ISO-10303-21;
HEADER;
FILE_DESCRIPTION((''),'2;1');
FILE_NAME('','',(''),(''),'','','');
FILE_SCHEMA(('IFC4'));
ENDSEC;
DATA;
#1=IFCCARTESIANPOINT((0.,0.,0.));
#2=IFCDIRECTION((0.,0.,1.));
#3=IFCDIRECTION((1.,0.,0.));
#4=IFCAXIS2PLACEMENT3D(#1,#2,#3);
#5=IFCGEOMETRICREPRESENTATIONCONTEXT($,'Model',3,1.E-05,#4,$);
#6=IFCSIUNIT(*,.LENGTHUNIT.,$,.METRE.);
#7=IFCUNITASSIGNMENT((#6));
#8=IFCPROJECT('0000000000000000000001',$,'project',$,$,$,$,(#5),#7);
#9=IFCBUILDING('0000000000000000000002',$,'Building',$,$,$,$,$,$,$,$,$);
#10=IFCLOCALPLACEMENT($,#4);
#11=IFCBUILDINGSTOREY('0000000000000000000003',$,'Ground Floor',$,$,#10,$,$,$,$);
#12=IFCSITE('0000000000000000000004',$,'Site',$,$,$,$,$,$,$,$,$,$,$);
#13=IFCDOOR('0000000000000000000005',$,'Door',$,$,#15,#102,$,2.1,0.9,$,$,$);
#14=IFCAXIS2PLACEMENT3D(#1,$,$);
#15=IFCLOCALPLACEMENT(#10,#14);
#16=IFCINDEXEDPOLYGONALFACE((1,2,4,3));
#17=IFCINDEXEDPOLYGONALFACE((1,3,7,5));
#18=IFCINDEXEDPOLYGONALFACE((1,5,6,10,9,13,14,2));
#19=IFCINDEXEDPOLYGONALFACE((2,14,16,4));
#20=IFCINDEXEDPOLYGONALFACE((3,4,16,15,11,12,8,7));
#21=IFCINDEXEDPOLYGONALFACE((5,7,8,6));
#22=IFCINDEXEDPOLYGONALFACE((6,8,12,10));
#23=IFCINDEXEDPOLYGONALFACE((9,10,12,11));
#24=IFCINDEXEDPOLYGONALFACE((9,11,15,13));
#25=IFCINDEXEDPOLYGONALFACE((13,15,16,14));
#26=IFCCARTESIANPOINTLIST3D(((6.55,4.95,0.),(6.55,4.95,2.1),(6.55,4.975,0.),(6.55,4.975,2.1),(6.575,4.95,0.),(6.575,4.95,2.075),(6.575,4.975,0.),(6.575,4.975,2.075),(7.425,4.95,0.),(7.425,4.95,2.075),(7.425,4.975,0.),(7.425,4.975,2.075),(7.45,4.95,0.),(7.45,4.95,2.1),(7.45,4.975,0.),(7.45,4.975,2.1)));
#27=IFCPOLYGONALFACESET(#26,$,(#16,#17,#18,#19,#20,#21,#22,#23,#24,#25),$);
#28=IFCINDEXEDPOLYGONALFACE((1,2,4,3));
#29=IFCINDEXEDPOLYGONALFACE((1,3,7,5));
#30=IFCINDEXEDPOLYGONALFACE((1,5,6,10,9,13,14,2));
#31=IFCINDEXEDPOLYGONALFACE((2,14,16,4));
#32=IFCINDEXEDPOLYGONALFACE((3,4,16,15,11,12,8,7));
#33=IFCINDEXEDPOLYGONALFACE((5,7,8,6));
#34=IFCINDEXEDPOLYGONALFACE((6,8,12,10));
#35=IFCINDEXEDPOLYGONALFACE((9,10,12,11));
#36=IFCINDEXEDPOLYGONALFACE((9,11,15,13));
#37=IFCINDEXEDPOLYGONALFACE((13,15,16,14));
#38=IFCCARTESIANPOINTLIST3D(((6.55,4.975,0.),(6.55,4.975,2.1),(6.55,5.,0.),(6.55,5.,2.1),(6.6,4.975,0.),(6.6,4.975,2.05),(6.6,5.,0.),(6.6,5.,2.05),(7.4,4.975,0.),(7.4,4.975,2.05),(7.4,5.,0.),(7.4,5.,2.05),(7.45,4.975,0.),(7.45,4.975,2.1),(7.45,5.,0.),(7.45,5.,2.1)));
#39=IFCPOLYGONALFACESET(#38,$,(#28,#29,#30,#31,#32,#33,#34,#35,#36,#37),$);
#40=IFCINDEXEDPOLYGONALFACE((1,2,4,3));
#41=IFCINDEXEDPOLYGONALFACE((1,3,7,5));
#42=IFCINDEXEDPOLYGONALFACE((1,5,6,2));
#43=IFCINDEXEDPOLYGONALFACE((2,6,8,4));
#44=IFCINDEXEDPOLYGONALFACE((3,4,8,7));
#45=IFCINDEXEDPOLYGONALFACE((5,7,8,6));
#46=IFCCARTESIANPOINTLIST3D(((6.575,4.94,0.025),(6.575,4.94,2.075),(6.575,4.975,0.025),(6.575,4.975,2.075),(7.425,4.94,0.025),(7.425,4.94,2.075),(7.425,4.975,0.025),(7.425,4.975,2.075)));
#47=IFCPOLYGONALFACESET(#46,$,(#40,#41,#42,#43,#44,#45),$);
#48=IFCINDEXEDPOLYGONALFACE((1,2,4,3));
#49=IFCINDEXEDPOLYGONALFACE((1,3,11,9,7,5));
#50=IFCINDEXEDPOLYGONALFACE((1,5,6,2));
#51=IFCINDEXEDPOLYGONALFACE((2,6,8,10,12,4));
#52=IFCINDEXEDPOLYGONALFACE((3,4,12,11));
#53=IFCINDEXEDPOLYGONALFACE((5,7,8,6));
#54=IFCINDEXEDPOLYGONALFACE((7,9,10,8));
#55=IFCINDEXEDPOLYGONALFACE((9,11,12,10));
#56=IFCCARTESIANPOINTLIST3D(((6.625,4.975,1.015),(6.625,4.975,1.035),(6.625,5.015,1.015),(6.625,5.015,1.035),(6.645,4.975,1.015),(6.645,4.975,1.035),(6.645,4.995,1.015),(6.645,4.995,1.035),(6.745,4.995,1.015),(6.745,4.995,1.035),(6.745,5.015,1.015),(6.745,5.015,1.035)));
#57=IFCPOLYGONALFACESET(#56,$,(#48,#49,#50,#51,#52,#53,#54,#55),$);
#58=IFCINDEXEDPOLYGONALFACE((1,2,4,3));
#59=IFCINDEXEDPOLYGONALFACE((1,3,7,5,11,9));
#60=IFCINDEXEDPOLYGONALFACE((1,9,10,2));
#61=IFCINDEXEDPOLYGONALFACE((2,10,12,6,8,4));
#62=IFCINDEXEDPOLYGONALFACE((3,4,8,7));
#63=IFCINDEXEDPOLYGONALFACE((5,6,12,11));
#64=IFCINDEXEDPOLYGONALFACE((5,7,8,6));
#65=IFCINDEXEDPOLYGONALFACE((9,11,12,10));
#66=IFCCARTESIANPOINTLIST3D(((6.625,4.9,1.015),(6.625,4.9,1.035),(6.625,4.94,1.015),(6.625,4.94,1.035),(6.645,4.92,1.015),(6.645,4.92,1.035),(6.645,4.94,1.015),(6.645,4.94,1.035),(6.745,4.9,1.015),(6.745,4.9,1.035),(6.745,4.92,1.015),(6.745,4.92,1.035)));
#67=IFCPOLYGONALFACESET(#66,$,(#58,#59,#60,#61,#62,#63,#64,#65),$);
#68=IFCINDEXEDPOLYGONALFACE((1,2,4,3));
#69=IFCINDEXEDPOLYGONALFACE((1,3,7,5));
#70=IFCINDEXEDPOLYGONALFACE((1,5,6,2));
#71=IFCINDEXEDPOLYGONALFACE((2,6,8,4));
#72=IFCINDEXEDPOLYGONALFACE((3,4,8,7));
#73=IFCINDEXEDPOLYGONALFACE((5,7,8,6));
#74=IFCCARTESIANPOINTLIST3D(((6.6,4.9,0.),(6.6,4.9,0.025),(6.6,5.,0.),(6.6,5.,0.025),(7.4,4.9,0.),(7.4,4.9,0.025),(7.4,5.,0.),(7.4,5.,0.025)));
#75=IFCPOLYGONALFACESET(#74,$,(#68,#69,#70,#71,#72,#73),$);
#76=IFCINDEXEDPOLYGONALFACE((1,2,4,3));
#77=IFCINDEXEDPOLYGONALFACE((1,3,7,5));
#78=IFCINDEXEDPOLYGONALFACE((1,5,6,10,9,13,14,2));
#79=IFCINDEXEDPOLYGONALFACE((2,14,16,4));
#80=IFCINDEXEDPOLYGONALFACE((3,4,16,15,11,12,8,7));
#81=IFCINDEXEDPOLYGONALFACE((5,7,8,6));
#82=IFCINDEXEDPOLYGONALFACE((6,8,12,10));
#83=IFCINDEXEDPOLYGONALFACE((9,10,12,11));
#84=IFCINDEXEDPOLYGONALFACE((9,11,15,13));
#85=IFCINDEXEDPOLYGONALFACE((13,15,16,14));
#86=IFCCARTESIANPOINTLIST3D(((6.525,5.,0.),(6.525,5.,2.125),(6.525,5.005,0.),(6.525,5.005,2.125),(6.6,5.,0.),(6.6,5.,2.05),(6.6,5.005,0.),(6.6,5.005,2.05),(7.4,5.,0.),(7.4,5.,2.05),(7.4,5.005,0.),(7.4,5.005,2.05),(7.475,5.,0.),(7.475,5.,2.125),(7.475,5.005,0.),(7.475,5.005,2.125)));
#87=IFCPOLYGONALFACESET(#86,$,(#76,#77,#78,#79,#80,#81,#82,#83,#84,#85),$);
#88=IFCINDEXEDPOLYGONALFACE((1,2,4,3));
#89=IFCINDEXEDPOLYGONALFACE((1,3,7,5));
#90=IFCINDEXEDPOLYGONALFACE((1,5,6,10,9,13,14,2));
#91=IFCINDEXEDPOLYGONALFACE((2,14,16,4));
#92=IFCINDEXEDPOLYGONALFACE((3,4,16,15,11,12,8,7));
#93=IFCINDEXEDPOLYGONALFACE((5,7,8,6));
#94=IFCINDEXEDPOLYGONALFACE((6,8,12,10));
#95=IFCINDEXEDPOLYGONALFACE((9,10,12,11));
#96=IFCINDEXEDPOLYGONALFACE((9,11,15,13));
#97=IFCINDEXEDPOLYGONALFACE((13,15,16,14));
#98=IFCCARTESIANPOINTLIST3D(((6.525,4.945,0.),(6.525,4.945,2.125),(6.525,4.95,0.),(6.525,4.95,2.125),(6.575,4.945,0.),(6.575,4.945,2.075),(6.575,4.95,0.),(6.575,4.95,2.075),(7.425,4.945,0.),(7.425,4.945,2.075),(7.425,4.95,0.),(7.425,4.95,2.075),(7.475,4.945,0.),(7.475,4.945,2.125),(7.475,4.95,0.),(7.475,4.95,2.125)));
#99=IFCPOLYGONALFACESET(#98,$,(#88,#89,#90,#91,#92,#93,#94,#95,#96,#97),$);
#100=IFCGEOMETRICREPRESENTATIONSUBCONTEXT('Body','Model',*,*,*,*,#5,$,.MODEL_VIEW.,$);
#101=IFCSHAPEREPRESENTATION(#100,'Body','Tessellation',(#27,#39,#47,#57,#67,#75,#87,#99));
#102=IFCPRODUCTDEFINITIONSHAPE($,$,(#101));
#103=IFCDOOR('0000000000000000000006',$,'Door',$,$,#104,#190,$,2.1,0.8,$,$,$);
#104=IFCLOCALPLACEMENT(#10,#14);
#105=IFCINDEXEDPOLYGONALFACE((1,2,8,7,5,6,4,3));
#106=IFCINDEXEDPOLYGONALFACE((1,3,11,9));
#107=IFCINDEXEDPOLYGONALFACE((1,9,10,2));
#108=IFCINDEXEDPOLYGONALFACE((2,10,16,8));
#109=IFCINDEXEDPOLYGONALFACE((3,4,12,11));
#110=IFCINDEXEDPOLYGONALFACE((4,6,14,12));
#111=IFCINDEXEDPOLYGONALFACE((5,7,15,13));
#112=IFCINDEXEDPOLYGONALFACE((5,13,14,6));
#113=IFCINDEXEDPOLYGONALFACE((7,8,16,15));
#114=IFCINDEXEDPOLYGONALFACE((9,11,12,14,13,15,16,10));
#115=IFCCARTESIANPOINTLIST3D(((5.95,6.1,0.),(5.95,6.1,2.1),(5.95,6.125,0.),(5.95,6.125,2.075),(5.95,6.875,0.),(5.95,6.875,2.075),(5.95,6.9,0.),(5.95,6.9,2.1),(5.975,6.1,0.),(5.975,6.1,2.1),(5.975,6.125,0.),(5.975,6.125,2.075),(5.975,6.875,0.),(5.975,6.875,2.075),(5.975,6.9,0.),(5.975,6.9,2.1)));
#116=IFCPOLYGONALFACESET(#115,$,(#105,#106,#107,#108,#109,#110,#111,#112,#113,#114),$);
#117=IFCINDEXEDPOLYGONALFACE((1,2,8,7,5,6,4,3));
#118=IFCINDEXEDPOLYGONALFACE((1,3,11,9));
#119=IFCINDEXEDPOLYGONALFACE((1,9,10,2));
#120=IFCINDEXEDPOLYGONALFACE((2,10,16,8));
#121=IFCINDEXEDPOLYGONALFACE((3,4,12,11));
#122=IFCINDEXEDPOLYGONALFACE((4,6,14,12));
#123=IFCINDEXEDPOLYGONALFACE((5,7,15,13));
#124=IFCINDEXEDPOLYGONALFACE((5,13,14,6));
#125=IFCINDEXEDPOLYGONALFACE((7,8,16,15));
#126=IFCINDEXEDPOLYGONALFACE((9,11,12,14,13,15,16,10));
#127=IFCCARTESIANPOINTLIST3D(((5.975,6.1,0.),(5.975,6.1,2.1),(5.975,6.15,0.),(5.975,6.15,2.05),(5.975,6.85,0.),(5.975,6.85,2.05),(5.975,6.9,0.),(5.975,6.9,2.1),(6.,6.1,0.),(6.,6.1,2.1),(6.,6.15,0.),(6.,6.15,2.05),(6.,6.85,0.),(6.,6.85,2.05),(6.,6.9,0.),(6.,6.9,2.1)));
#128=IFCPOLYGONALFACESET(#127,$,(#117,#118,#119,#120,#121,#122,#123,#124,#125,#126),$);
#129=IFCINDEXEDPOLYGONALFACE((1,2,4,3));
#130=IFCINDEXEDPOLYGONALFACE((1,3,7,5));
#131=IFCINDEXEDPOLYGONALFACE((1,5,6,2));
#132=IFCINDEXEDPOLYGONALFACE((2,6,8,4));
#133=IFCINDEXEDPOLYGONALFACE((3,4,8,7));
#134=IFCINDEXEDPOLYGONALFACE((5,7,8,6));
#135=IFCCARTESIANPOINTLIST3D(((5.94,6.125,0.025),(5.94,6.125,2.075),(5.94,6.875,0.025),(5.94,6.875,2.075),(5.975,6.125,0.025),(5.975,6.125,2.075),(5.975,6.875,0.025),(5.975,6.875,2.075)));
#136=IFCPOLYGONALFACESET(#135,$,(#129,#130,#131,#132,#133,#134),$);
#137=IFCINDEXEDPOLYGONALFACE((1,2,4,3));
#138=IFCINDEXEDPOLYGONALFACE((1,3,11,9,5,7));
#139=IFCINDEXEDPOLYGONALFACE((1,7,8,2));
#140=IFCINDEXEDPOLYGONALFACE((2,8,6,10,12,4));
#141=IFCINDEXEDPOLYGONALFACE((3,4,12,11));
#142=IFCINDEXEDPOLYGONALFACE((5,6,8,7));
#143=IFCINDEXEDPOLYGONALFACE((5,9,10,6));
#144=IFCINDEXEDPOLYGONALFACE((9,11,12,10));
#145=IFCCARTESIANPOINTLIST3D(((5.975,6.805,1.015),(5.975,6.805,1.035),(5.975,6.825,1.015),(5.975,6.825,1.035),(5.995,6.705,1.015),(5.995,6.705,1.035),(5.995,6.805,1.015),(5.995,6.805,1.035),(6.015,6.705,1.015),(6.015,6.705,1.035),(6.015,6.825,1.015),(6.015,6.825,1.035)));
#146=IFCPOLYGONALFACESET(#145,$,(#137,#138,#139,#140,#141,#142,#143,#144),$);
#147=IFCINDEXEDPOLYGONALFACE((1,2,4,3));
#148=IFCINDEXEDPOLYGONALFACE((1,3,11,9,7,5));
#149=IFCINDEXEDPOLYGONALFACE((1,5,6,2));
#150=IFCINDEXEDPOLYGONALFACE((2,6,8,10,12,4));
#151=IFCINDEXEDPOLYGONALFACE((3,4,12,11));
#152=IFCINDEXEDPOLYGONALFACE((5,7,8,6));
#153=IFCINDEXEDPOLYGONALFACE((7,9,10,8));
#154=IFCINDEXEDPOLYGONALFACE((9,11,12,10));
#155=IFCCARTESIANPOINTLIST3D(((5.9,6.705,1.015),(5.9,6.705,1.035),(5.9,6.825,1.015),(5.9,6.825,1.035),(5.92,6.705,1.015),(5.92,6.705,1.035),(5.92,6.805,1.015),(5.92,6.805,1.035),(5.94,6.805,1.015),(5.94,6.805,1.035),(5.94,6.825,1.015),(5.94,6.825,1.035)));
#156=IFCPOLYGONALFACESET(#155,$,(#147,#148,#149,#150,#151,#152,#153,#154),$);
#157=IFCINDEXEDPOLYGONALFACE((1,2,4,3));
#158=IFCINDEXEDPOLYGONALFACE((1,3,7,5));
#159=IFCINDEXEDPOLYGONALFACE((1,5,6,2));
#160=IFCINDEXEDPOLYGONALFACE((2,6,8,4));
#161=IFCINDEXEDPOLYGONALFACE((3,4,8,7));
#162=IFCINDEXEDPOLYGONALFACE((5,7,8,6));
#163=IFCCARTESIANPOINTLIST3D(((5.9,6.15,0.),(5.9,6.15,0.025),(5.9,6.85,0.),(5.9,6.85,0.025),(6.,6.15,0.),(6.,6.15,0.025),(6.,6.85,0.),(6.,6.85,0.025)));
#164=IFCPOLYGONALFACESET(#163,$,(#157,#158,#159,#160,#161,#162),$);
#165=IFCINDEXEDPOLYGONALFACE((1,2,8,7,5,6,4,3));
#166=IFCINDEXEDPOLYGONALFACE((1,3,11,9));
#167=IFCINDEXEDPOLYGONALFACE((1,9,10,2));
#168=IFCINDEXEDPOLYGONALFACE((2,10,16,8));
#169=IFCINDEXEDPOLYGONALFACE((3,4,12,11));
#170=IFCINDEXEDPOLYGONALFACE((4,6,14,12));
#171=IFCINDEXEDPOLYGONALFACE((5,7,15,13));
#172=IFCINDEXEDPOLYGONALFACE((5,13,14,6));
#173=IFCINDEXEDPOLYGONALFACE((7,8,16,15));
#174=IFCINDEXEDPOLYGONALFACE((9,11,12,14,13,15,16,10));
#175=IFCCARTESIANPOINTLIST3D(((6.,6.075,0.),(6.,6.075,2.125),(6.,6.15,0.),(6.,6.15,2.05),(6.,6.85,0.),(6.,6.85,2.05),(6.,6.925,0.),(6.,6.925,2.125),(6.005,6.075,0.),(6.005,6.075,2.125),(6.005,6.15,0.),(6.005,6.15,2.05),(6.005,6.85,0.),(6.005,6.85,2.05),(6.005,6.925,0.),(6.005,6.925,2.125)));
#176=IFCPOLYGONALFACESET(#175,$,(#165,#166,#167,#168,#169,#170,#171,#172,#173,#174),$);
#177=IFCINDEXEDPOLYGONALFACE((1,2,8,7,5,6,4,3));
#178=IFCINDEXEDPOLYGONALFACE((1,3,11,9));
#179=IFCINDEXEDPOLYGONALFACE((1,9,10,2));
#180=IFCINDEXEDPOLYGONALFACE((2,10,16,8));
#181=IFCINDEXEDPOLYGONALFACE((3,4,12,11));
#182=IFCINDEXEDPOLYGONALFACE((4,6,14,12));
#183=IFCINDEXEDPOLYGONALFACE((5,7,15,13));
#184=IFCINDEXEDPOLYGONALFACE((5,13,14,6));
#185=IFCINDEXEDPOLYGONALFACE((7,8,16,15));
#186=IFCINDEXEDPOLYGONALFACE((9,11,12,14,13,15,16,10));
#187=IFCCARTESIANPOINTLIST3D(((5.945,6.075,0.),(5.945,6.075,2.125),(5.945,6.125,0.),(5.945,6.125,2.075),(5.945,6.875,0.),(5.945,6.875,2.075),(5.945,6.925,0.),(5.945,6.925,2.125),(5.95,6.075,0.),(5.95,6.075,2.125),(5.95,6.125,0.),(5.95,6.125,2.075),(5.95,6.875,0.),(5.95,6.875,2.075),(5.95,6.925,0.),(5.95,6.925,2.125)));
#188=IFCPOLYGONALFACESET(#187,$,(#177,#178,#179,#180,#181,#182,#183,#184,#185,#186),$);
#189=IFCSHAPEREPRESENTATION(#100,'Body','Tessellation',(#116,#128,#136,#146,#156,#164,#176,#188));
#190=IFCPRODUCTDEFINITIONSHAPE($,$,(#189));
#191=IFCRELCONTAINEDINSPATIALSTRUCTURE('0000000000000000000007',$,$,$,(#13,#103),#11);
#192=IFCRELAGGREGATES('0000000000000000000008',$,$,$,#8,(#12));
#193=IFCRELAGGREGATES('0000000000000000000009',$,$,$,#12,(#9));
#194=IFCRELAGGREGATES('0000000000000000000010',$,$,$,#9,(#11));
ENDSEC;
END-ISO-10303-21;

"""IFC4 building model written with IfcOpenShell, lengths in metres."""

from ifc_helpers import new_model, si_unit, frame, origin_with_axes, place, context, subcontext, project, spatial, line, indexed_curve, outline, extrude, element, save


model = new_model("IFC4")

# Units and contexts
model_context = context("Model", 3, precision=1e-05, world=origin_with_axes())
body_context = subcontext(model_context, "Body", "Model", "MODEL_VIEW")
ifc_project = project(units=[si_unit("LENGTHUNIT", "METRE")], contexts=[model_context])

# Site, building, storey
site = spatial("IfcSite", under=ifc_project, Name="Site")
building = spatial("IfcBuilding", under=site, Name="Building")
storey_placement = place(None, origin_with_axes())
storey = spatial("IfcBuildingStorey", under=building, at=storey_placement, Name="Ground Floor")

# Doors
door_1_placement = place(storey_placement, frame((7.45, 5.0, 0.0), z_axis=(0.0, 0.0, 1.0), x_axis=(-1.0, 0.0, 0.0)))
element("IfcDoor", 1, at=door_1_placement, inside=storey, Name="Door", OverallHeight=2.1, OverallWidth=0.9, context=body_context, shape_type="SweptSolid", body=[
    extrude(outline(indexed_curve([(0.0, 0.0), (0.0, 2.1), (0.9, 2.1), (0.9, 0.0), (0.875, 0.0), (0.875, 2.075), (0.025, 2.075), (0.025, 0.0)], segments=[line(1, 2, 3, 4, 5, 6, 7, 8, 1)])), frame((0.0, 0.025, 0.0), z_axis=(0.0, -1.0, 0.0), x_axis=(1.0, 0.0, 0.0)), (0.0, 0.0, -1.0), 0.025),
    extrude(outline(indexed_curve([(0.0, 0.0), (0.0, 2.1), (0.9, 2.1), (0.9, 0.0), (0.85, 0.0), (0.85, 2.05), (0.05, 2.05), (0.05, 0.0)], segments=[line(1, 2, 3, 4, 5, 6, 7, 8, 1)])), frame((0.0, 0.0, 0.0), z_axis=(0.0, -1.0, 0.0), x_axis=(1.0, 0.0, 0.0)), (0.0, 0.0, -1.0), 0.025),
    extrude(outline(indexed_curve([(0.0, 0.0), (0.85, 0.0), (0.85, 0.035), (0.0, 0.035)], segments=[line(1, 2, 3, 4, 1)])), frame((0.025, 0.025, 0.025), z_axis=(0.0, 0.0, 1.0), x_axis=(1.0, 0.0, 0.0)), (0.0, 0.0, 1.0), 2.05),
    extrude(outline(indexed_curve([(0.0, 0.0), (0.0, -0.04), (-0.12, -0.04), (-0.12, -0.02), (-0.02, -0.02), (-0.02, 0.0)], segments=[line(1, 2, 3, 4, 5, 6, 1)])), frame((0.825, 0.025, 1.015), z_axis=(0.0, 0.0, 1.0), x_axis=(1.0, 0.0, 0.0)), (0.0, 0.0, 1.0), 0.02),
    extrude(outline(indexed_curve([(0.0, 0.0), (0.0, 0.04), (-0.12, 0.04), (-0.12, 0.02), (-0.02, 0.02), (-0.02, 0.0)], segments=[line(1, 2, 3, 4, 5, 6, 1)])), frame((0.825, 0.06, 1.015), z_axis=(0.0, 0.0, 1.0), x_axis=(1.0, 0.0, 0.0)), (0.0, 0.0, 1.0), 0.02),
    extrude(outline(indexed_curve([(0.0, 0.0), (0.8, 0.0), (0.8, 0.1), (0.0, 0.1)], segments=[line(1, 2, 3, 4, 1)])), frame((0.05, 0.0, 0.0), z_axis=(0.0, 0.0, 1.0), x_axis=(1.0, 0.0, 0.0)), (0.0, 0.0, 1.0), 0.025),
    extrude(outline(indexed_curve([(0.0, 0.0), (0.0, 2.125), (0.95, 2.125), (0.95, 0.0), (0.875, 0.0), (0.875, 2.05), (0.075, 2.05), (0.075, 0.0)], segments=[line(1, 2, 3, 4, 5, 6, 7, 8, 1)])), frame((-0.025, -0.005, 0.0), z_axis=(0.0, -1.0, 0.0), x_axis=(1.0, 0.0, 0.0)), (0.0, 0.0, -1.0), 0.005),
    extrude(outline(indexed_curve([(0.0, 0.0), (0.0, 2.125), (0.95, 2.125), (0.95, 0.0), (0.9, 0.0), (0.9, 2.075), (0.05, 2.075), (0.05, 0.0)], segments=[line(1, 2, 3, 4, 5, 6, 7, 8, 1)])), frame((-0.025, 0.05, 0.0), z_axis=(0.0, -1.0, 0.0), x_axis=(1.0, 0.0, 0.0)), (0.0, 0.0, -1.0), 0.005),
])
door_2_placement = place(storey_placement, frame((6.0, 6.1, 0.0), z_axis=(0.0, 0.0, 1.0), x_axis=(0.0, 1.0, 0.0)))
element("IfcDoor", 2, at=door_2_placement, inside=storey, Name="Door", OverallHeight=2.1, OverallWidth=0.8, context=body_context, shape_type="SweptSolid", body=[
    extrude(outline(indexed_curve([(0.0, 0.0), (0.0, 2.1), (0.8, 2.1), (0.8, 0.0), (0.775, 0.0), (0.775, 2.075), (0.025, 2.075), (0.025, 0.0)], segments=[line(1, 2, 3, 4, 5, 6, 7, 8, 1)])), frame((0.0, 0.025, 0.0), z_axis=(0.0, -1.0, 0.0), x_axis=(1.0, 0.0, 0.0)), (0.0, 0.0, -1.0), 0.025),
    extrude(outline(indexed_curve([(0.0, 0.0), (0.0, 2.1), (0.8, 2.1), (0.8, 0.0), (0.75, 0.0), (0.75, 2.05), (0.05, 2.05), (0.05, 0.0)], segments=[line(1, 2, 3, 4, 5, 6, 7, 8, 1)])), frame((0.0, 0.0, 0.0), z_axis=(0.0, -1.0, 0.0), x_axis=(1.0, 0.0, 0.0)), (0.0, 0.0, -1.0), 0.025),
    extrude(outline(indexed_curve([(0.0, 0.0), (0.75, 0.0), (0.75, 0.035), (0.0, 0.035)], segments=[line(1, 2, 3, 4, 1)])), frame((0.025, 0.025, 0.025), z_axis=(0.0, 0.0, 1.0), x_axis=(1.0, 0.0, 0.0)), (0.0, 0.0, 1.0), 2.05),
    extrude(outline(indexed_curve([(0.0, 0.0), (0.0, -0.04), (-0.12, -0.04), (-0.12, -0.02), (-0.02, -0.02), (-0.02, 0.0)], segments=[line(1, 2, 3, 4, 5, 6, 1)])), frame((0.725, 0.025, 1.015), z_axis=(0.0, 0.0, 1.0), x_axis=(1.0, 0.0, 0.0)), (0.0, 0.0, 1.0), 0.02),
    extrude(outline(indexed_curve([(0.0, 0.0), (0.0, 0.04), (-0.12, 0.04), (-0.12, 0.02), (-0.02, 0.02), (-0.02, 0.0)], segments=[line(1, 2, 3, 4, 5, 6, 1)])), frame((0.725, 0.06, 1.015), z_axis=(0.0, 0.0, 1.0), x_axis=(1.0, 0.0, 0.0)), (0.0, 0.0, 1.0), 0.02),
    extrude(outline(indexed_curve([(0.0, 0.0), (0.7, 0.0), (0.7, 0.1), (0.0, 0.1)], segments=[line(1, 2, 3, 4, 1)])), frame((0.05, 0.0, 0.0), z_axis=(0.0, 0.0, 1.0), x_axis=(1.0, 0.0, 0.0)), (0.0, 0.0, 1.0), 0.025),
    extrude(outline(indexed_curve([(0.0, 0.0), (0.0, 2.125), (0.85, 2.125), (0.85, 0.0), (0.775, 0.0), (0.775, 2.05), (0.075, 2.05), (0.075, 0.0)], segments=[line(1, 2, 3, 4, 5, 6, 7, 8, 1)])), frame((-0.025, -0.005, 0.0), z_axis=(0.0, -1.0, 0.0), x_axis=(1.0, 0.0, 0.0)), (0.0, 0.0, -1.0), 0.005),
    extrude(outline(indexed_curve([(0.0, 0.0), (0.0, 2.125), (0.85, 2.125), (0.85, 0.0), (0.8, 0.0), (0.8, 2.075), (0.05, 2.075), (0.05, 0.0)], segments=[line(1, 2, 3, 4, 5, 6, 7, 8, 1)])), frame((-0.025, 0.05, 0.0), z_axis=(0.0, -1.0, 0.0), x_axis=(1.0, 0.0, 0.0)), (0.0, 0.0, -1.0), 0.005),
])

save(model, "model.ifc")
